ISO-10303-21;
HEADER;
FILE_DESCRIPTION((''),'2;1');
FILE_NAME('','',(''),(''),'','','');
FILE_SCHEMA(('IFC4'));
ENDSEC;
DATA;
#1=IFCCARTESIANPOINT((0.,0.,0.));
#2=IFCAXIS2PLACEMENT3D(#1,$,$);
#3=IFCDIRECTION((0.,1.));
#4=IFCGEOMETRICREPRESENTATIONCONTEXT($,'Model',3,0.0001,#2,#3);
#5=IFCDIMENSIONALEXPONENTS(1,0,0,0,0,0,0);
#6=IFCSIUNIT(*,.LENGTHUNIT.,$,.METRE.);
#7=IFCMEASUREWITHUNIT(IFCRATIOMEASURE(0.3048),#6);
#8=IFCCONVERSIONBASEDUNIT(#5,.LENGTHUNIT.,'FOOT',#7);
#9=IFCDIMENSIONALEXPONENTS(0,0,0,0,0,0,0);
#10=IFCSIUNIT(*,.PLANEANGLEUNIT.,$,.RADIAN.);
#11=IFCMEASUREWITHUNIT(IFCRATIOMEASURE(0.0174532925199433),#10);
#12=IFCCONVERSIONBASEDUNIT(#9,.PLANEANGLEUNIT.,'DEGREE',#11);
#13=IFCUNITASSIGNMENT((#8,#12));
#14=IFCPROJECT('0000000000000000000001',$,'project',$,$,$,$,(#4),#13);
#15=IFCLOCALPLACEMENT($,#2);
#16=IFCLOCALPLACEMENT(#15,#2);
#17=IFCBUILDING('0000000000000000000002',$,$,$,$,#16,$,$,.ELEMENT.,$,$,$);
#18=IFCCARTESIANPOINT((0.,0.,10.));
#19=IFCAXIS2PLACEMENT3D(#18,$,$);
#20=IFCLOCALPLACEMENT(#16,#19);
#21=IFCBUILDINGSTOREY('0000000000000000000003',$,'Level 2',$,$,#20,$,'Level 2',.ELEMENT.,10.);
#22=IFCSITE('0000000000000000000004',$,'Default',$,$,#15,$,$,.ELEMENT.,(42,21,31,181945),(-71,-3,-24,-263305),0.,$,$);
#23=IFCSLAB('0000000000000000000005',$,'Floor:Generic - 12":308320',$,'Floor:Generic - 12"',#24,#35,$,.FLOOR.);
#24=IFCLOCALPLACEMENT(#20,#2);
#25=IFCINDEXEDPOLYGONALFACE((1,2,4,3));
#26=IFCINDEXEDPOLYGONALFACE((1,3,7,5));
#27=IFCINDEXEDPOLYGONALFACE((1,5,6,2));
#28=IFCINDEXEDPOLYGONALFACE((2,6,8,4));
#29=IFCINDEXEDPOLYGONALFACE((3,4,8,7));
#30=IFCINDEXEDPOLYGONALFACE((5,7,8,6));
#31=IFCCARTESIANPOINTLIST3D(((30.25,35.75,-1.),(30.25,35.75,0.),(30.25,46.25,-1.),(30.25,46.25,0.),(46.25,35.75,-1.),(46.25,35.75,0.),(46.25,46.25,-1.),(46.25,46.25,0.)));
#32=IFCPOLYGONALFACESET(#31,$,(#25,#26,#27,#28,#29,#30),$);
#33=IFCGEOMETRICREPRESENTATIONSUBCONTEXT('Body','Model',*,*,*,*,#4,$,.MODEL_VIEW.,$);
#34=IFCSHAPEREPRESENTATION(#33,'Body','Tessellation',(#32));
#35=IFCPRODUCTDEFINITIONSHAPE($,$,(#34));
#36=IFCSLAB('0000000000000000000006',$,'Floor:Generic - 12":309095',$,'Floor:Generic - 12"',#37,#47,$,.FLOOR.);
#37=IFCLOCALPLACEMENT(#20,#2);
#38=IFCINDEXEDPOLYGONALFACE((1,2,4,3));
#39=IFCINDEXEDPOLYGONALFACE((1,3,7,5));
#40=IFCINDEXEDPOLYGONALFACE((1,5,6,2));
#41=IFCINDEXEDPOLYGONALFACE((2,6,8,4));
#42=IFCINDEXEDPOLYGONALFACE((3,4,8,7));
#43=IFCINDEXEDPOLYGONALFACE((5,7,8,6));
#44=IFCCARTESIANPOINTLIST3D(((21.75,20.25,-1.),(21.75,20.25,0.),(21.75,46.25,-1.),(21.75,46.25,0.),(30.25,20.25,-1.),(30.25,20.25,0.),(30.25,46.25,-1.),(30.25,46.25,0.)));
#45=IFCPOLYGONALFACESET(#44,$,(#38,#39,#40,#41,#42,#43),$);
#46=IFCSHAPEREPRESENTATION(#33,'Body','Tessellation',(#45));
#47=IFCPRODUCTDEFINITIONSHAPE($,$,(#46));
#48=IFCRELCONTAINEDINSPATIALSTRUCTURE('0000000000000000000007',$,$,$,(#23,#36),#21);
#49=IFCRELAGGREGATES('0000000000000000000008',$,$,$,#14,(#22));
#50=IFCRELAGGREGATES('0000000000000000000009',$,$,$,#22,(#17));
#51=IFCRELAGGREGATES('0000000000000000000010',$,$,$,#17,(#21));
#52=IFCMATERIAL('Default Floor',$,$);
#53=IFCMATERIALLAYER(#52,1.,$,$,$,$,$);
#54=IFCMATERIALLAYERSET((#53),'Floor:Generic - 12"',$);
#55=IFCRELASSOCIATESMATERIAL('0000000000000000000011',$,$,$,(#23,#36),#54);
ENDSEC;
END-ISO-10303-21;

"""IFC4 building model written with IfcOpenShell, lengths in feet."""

from ifc_helpers import new_model, entity, si_unit, converted_unit, direction, frame, frame_2d, origin, place, context, subcontext, project, spatial, rectangle, extrude, material, layer, layer_set, layer_usage, element, save


model = new_model("IFC4")

# Units and contexts
model_context = context("Model", 3, precision=0.0001, world=origin(), true_north=direction((0.0, 1.0)))
body_context = subcontext(model_context, "Body", "Model", "MODEL_VIEW")
ifc_project = project(units=[converted_unit("LENGTHUNIT", "FOOT", entity("IfcRatioMeasure", 0.3048), si_unit("LENGTHUNIT", "METRE"), dimensions=[1, 0, 0, 0, 0, 0, 0]), converted_unit("PLANEANGLEUNIT", "DEGREE", entity("IfcRatioMeasure", 0.0174532925199433), si_unit("PLANEANGLEUNIT", "RADIAN"), dimensions=[0, 0, 0, 0, 0, 0, 0])], contexts=[model_context])

# Site, building, storey
site_placement = place(None, origin())
site = spatial("IfcSite", under=ifc_project, at=site_placement, Name="Default", CompositionType="ELEMENT", RefLatitude=(42, 21, 31, 181945), RefLongitude=(-71, -3, -24, -263305), RefElevation=0.0)
building_placement = place(site_placement, origin())
building = spatial("IfcBuilding", under=site, at=building_placement, CompositionType="ELEMENT")
storey_placement = place(building_placement, frame((0.0, 0.0, 10.0)))
storey = spatial("IfcBuildingStorey", under=building, at=storey_placement, Name="Level 2", LongName="Level 2", CompositionType="ELEMENT", Elevation=10.0)

# Slabs
ifc_material = material(Name="Default Floor")
ifc_layer = layer(ifc_material, 1.0)
ifc_layer_set = layer_set([ifc_layer], Name="Floor:Generic - 12\"")
ifc_layer_usage_1 = layer_usage(ifc_layer_set, "AXIS3", "POSITIVE", 0.0)
slab_1_placement = place(storey_placement, origin())
element("IfcSlab", 1, at=slab_1_placement, inside=storey, material=ifc_layer_usage_1, Name="Floor:Generic - 12\":308320", ObjectType="Floor:Generic - 12\"", PredefinedType="FLOOR", context=body_context, shape_type="SweptSolid", body=[
    extrude(rectangle(XDim=10.5, YDim=16.0, at=frame_2d((0.0, 0.0), x_axis=(1.0, 0.0))), frame((38.25, 41.0, 0.0), z_axis=(0.0, 0.0, -1.0), x_axis=(0.0, 1.0, 0.0)), (0.0, 0.0, 1.0), 1.0),
])
ifc_layer_usage_2 = layer_usage(ifc_layer_set, "AXIS3", "POSITIVE", 0.0)
slab_2_placement = place(storey_placement, origin())
element("IfcSlab", 2, at=slab_2_placement, inside=storey, material=ifc_layer_usage_2, Name="Floor:Generic - 12\":309095", ObjectType="Floor:Generic - 12\"", PredefinedType="FLOOR", context=body_context, shape_type="SweptSolid", body=[
    extrude(rectangle(XDim=26.0, YDim=8.5, at=frame_2d((0.0, 0.0), x_axis=(1.0, 0.0))), frame((26.0, 33.25, 0.0), z_axis=(0.0, 0.0, -1.0), x_axis=(0.0, 1.0, 0.0)), (0.0, 0.0, 1.0), 1.0),
])

save(model, "model.ifc")
